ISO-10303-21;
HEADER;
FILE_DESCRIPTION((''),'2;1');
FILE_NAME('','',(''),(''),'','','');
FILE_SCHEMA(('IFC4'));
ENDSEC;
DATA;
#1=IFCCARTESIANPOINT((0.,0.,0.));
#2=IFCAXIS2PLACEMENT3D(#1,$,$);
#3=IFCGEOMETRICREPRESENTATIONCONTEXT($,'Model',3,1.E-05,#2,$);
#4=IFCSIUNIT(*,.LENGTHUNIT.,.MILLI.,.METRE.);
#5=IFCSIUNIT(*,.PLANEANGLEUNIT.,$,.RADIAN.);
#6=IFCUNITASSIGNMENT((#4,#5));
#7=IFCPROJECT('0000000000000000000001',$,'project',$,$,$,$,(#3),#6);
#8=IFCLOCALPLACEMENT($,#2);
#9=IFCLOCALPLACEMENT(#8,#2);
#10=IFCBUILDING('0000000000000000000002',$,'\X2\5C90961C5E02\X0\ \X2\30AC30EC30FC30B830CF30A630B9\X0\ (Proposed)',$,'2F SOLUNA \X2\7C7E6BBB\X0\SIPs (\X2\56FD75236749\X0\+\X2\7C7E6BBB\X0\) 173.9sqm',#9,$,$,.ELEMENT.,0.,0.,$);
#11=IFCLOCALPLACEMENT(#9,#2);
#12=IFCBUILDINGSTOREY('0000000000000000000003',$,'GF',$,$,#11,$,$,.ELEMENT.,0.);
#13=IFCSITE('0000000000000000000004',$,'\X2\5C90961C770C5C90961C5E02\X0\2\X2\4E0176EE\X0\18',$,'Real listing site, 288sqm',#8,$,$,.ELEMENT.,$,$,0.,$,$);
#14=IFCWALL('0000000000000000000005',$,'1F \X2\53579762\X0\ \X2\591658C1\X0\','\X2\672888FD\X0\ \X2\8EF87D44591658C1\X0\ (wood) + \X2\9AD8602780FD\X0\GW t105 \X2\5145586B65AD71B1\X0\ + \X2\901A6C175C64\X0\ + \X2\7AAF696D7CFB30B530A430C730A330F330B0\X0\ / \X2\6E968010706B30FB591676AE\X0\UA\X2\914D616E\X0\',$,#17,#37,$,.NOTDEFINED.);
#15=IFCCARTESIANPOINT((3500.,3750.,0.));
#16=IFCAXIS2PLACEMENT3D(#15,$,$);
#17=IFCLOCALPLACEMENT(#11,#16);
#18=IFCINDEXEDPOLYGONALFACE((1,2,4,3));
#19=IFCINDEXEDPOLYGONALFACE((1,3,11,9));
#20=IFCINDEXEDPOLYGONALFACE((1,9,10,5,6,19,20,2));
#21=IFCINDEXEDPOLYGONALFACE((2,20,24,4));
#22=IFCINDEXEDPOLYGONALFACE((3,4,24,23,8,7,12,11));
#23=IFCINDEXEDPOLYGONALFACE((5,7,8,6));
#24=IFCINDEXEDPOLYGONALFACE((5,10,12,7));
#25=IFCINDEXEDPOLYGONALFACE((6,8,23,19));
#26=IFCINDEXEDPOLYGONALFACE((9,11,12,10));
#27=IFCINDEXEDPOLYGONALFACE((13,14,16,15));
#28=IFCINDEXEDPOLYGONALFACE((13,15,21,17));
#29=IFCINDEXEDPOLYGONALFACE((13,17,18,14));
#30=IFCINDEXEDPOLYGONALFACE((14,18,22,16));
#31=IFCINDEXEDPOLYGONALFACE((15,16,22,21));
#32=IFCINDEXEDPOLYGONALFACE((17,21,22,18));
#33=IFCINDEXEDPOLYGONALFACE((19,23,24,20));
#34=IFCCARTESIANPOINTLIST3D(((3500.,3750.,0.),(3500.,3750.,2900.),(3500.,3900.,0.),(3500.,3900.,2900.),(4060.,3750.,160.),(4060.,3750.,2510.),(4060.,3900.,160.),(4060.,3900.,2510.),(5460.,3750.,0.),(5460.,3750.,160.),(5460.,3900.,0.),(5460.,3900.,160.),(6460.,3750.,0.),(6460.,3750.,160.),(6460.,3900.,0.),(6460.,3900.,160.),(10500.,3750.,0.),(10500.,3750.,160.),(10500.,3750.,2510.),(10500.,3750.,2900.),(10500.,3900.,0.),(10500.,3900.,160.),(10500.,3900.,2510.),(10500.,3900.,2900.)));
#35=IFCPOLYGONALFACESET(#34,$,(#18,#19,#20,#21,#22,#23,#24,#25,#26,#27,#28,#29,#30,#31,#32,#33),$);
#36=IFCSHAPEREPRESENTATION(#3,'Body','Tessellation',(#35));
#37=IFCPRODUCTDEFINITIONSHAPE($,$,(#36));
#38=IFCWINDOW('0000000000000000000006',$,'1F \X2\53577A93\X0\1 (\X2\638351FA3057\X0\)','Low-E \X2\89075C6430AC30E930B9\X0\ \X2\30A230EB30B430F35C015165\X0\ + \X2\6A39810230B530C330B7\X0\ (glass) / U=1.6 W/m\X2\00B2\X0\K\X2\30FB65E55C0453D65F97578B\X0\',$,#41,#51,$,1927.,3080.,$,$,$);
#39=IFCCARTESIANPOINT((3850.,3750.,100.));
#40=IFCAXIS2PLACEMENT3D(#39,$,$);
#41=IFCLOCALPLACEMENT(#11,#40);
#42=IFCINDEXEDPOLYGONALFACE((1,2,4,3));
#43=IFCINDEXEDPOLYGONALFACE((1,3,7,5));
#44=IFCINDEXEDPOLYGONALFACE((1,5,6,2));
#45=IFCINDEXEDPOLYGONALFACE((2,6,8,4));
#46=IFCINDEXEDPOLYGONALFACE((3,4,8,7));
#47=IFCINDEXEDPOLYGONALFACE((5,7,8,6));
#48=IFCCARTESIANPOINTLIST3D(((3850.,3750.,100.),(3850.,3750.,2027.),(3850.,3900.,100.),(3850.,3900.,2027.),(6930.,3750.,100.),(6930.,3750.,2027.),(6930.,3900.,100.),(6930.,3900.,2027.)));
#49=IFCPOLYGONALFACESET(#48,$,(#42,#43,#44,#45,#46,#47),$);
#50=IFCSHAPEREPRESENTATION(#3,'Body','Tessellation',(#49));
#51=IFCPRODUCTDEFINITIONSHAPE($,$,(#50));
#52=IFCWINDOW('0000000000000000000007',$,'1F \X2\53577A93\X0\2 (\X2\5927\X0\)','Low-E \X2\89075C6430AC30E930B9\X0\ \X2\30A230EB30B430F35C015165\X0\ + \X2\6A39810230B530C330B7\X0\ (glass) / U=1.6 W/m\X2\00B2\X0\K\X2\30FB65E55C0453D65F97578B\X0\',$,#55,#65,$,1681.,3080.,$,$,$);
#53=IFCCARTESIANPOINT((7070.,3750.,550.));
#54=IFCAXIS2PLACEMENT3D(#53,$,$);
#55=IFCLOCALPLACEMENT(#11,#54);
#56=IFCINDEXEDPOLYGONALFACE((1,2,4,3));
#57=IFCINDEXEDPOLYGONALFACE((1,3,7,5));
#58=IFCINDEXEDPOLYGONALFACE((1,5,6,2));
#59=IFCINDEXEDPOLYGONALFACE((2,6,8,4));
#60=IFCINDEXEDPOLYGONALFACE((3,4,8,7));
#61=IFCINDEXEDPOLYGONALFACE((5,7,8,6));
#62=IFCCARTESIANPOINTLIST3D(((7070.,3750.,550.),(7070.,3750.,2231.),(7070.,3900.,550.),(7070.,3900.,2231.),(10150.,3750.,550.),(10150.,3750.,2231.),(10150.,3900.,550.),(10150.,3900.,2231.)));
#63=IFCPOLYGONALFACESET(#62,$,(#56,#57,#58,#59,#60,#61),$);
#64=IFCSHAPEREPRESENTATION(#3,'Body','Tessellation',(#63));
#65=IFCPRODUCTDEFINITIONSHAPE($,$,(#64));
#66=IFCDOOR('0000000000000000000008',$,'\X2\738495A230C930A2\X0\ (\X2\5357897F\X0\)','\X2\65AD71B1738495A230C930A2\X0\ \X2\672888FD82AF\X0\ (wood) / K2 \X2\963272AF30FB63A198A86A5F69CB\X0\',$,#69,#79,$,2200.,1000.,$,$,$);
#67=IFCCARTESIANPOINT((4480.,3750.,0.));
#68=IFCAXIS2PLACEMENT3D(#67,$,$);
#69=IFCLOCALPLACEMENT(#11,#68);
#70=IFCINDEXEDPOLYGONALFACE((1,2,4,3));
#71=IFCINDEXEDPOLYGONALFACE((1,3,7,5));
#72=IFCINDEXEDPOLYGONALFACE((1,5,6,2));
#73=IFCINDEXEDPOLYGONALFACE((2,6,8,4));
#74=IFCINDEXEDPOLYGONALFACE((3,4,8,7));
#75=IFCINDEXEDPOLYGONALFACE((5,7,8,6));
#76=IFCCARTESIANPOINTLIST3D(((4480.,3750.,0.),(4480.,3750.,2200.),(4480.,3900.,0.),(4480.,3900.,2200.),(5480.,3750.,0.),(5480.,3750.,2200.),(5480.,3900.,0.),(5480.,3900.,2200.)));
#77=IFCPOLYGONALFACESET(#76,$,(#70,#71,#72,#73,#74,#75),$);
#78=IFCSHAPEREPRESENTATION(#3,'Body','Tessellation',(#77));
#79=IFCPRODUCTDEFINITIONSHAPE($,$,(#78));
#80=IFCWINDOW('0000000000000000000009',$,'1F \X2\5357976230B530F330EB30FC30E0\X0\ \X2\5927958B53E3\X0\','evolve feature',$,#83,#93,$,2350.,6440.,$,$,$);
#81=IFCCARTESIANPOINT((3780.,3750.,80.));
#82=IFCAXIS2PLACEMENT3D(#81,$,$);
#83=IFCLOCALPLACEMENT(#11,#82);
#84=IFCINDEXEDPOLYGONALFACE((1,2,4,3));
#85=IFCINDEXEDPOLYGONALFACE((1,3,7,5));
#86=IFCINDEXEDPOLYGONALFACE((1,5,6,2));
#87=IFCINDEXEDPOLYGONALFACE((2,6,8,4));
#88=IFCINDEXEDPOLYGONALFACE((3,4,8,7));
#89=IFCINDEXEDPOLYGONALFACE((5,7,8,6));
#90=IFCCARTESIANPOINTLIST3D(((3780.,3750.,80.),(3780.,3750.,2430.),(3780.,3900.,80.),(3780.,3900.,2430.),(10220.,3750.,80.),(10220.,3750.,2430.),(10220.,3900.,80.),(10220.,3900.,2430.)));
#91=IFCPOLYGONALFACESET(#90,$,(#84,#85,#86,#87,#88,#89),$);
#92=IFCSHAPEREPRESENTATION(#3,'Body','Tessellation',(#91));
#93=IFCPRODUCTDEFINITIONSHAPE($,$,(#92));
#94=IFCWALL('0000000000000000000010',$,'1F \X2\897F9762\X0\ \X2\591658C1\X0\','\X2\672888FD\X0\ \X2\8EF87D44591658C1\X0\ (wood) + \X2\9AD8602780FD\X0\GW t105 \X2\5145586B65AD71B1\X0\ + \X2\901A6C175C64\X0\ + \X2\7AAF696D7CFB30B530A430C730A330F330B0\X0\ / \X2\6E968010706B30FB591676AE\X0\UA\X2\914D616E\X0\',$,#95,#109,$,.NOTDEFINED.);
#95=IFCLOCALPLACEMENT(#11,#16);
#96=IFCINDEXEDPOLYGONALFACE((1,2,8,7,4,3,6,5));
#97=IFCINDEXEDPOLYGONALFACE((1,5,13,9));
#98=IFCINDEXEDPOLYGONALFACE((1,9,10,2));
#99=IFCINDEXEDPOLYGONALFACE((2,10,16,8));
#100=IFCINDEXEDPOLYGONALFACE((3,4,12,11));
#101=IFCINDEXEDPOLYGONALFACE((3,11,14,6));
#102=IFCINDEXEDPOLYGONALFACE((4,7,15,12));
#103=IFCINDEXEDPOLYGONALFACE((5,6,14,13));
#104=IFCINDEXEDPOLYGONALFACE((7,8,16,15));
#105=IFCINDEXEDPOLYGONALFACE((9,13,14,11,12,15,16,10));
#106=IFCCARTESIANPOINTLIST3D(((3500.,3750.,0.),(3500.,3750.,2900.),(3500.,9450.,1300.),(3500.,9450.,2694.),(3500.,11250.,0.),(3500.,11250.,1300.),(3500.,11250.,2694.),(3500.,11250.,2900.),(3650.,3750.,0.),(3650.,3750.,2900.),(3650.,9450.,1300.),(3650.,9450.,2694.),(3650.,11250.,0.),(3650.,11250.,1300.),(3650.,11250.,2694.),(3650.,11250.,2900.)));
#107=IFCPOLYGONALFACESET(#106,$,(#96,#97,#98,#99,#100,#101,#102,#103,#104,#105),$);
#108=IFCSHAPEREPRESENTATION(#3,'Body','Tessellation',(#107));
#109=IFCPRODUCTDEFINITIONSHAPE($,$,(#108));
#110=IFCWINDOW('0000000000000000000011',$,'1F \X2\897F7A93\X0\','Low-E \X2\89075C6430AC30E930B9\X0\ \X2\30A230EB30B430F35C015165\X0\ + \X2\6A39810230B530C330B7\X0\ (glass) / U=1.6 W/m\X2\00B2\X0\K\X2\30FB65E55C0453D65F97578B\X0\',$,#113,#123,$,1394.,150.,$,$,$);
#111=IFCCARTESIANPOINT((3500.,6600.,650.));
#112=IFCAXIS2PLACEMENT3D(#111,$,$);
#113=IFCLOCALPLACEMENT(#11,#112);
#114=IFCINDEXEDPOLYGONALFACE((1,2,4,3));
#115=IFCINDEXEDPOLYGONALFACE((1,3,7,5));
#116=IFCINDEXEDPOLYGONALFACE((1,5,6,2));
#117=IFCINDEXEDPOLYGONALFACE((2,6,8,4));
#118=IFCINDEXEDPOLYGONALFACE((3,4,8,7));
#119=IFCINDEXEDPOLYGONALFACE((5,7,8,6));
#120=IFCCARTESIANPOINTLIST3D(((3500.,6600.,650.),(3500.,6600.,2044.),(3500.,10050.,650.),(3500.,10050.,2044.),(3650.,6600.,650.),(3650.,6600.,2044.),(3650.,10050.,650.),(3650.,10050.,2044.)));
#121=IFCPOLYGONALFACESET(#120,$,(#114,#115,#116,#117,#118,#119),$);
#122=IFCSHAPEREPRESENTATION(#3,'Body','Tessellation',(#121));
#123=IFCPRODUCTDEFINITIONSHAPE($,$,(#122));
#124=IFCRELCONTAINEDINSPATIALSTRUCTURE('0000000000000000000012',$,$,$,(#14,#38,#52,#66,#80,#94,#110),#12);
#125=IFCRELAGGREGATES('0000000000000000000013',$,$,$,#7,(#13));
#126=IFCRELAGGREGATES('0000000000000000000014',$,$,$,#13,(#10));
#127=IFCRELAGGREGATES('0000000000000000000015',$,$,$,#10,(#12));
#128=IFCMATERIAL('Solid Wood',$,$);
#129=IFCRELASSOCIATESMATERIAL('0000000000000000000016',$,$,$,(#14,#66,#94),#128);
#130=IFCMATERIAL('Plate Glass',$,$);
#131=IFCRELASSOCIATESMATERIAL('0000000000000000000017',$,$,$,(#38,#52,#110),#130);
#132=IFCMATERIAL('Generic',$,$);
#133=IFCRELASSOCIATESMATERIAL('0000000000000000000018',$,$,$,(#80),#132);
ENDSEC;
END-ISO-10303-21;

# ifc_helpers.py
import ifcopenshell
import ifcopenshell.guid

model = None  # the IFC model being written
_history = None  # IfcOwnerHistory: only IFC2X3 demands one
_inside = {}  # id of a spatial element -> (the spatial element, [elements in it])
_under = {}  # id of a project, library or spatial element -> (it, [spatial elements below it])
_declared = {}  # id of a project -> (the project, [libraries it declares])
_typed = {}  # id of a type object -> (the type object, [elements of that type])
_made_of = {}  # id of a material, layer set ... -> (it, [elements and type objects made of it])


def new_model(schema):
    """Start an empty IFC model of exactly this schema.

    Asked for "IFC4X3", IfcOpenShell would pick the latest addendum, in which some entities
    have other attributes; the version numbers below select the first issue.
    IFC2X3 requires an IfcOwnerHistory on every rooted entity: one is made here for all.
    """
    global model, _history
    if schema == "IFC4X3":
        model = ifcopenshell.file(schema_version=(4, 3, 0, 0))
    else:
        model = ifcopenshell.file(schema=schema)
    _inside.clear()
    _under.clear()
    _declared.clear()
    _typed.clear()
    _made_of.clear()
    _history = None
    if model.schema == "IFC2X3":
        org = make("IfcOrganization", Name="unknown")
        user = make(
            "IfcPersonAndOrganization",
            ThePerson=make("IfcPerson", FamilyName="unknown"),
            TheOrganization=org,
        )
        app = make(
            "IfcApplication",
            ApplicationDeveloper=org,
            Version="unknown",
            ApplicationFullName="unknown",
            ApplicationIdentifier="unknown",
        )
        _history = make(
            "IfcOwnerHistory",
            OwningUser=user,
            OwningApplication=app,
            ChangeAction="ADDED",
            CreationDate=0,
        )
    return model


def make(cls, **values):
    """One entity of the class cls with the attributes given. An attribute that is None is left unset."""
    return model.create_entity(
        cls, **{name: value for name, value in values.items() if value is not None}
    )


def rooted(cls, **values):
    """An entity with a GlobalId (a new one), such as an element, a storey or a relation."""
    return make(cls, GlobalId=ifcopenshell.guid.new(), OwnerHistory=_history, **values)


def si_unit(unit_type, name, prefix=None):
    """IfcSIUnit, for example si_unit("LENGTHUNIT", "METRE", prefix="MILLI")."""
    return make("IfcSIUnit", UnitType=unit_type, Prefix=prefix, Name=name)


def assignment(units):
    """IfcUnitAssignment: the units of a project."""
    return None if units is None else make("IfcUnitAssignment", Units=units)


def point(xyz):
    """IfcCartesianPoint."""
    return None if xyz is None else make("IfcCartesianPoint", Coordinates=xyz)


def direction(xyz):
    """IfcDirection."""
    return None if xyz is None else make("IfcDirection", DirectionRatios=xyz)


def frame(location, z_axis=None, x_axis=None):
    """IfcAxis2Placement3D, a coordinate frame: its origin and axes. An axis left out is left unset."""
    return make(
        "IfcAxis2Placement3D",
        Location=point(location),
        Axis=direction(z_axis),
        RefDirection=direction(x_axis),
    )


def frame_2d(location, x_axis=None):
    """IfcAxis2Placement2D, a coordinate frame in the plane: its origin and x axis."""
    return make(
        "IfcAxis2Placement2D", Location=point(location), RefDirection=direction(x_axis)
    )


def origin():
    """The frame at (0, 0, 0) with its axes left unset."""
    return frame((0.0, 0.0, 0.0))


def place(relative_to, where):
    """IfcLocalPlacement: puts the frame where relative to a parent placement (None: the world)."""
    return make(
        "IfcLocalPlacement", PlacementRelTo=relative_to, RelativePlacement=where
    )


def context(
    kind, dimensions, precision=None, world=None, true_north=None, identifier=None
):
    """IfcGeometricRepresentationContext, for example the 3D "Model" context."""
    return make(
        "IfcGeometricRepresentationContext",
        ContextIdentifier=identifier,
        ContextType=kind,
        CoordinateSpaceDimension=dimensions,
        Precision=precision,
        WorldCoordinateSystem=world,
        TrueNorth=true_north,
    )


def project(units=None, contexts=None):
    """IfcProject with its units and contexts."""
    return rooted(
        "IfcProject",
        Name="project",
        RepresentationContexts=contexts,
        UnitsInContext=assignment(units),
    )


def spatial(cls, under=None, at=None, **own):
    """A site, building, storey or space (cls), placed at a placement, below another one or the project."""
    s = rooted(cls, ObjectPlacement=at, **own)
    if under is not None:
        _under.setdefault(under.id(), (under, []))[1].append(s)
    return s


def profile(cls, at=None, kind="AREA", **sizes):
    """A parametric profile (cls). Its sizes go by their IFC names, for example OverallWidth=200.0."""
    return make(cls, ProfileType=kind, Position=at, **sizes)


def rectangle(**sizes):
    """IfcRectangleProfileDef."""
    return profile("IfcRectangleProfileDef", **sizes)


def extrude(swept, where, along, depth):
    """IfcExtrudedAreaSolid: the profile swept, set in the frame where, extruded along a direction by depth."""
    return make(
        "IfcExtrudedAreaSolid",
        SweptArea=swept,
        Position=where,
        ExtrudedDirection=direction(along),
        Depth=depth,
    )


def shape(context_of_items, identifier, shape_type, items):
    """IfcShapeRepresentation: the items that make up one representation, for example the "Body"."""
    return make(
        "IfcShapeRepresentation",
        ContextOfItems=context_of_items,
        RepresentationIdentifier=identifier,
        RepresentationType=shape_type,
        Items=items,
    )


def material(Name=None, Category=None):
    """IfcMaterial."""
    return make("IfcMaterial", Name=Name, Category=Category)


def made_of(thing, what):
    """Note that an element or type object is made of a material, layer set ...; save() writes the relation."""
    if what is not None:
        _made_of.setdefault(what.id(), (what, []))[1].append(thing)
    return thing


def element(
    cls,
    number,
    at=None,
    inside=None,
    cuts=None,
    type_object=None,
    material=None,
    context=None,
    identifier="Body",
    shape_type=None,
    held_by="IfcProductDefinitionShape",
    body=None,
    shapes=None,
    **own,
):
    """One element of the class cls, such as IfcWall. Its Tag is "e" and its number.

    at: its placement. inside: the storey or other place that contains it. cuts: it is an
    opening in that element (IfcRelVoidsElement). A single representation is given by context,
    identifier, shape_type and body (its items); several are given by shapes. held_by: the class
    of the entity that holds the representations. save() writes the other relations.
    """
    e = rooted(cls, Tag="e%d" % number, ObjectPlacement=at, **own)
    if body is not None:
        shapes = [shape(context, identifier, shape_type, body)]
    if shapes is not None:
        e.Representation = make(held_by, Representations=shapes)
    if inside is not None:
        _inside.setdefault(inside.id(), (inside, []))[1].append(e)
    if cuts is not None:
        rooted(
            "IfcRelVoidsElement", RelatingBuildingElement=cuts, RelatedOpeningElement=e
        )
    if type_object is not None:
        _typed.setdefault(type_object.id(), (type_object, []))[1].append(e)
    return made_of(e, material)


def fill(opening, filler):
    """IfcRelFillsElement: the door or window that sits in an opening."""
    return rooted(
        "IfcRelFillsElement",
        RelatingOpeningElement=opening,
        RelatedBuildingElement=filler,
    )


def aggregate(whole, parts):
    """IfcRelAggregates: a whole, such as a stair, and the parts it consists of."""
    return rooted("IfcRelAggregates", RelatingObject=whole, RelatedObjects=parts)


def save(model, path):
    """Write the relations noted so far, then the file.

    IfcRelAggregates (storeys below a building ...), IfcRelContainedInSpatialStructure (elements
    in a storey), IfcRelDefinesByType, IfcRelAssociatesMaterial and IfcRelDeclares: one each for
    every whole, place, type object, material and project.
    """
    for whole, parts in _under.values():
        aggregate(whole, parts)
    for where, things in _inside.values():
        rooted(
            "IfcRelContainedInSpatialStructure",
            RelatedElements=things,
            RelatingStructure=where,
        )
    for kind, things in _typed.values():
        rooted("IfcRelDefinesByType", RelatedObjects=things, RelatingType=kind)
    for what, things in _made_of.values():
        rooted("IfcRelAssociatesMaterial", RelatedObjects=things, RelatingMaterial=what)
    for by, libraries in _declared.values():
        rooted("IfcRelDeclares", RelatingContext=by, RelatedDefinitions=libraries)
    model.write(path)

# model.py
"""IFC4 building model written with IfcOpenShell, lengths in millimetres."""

from ifc_helpers import new_model, si_unit, frame, frame_2d, origin, place, context, project, spatial, rectangle, extrude, material, element, fill, save


model = new_model("IFC4")

# Units and contexts
model_context = context("Model", 3, precision=1e-05, world=origin())
ifc_project = project(units=[si_unit("LENGTHUNIT", "METRE", prefix="MILLI"), si_unit("PLANEANGLEUNIT", "RADIAN")], contexts=[model_context])

# Site, building, storey
site_placement = place(None, origin())
site = spatial("IfcSite", under=ifc_project, at=site_placement, Name="岐阜県岐阜市2丁目18", ObjectType="Real listing site, 288sqm", CompositionType="ELEMENT", RefElevation=0.0)
building_placement = place(site_placement, origin())
building = spatial("IfcBuilding", under=site, at=building_placement, Name="岐阜市 ガレージハウス (Proposed)", ObjectType="2F SOLUNA 籾殻SIPs (国産杉+籾殻) 173.9sqm", CompositionType="ELEMENT", ElevationOfRefHeight=0.0, ElevationOfTerrain=0.0)
storey_placement = place(building_placement, origin())
storey = spatial("IfcBuildingStorey", under=building, at=storey_placement, Name="GF", CompositionType="ELEMENT", Elevation=0.0)

# Shared definitions
ifc_material_1 = material(Name="Solid Wood")
ifc_material_2 = material(Name="Generic")

# Wall, openings, windows, door
wall_1_placement = place(storey_placement, frame((3500.0, 3750.0, 0.0)))
wall_1 = element("IfcWall", 1, at=wall_1_placement, inside=storey, material=ifc_material_1, Name="1F 南面 外壁", Description="木製 軸組外壁 (wood) + 高性能GW t105 充填断熱 + 通気層 + 窯業系サイディング / 準耐火・外皮UA配慮", PredefinedType="NOTDEFINED", context=model_context, shape_type="SweptSolid", body=[
    extrude(rectangle(XDim=7000.0, YDim=150.0, at=frame_2d((3500.0, 75.0))), frame((3500.0, 3750.0, 0.0)), (0.0, 0.0, 1.0), 2900.0),
])
opening_1_placement = place(storey_placement, frame((3850.0, 3750.0, 100.0)))
opening_1 = element("IfcOpeningElement", 2, at=opening_1_placement, cuts=wall_1, PredefinedType="NOTDEFINED", context=model_context, shape_type="SweptSolid", body=[
    extrude(rectangle(XDim=3080.0, YDim=150.0, at=frame_2d((1540.0, 75.0))), frame((3850.0, 3750.0, 100.0)), (0.0, 0.0, 1.0), 1927.0),
])
opening_2_placement = place(storey_placement, frame((7070.0, 3750.0, 550.0)))
opening_2 = element("IfcOpeningElement", 3, at=opening_2_placement, cuts=wall_1, PredefinedType="NOTDEFINED", context=model_context, shape_type="SweptSolid", body=[
    extrude(rectangle(XDim=3080.0, YDim=150.0, at=frame_2d((1540.0, 75.0))), frame((7070.0, 3750.0, 550.0)), (0.0, 0.0, 1.0), 1681.0),
])
opening_3_placement = place(storey_placement, frame((4480.0, 3750.0, 0.0)))
opening_3 = element("IfcOpeningElement", 4, at=opening_3_placement, cuts=wall_1, PredefinedType="NOTDEFINED", context=model_context, shape_type="SweptSolid", body=[
    extrude(rectangle(XDim=1000.0, YDim=150.0, at=frame_2d((500.0, 75.0))), frame((4480.0, 3750.0, 0.0)), (0.0, 0.0, 1.0), 2200.0),
])
opening_4_placement = place(storey_placement, frame((3780.0, 3750.0, 80.0)))
opening_4 = element("IfcOpeningElement", 5, at=opening_4_placement, cuts=wall_1, PredefinedType="NOTDEFINED", context=model_context, shape_type="SweptSolid", body=[
    extrude(rectangle(XDim=6440.0, YDim=150.0, at=frame_2d((3220.0, 75.0))), frame((3780.0, 3750.0, 80.0)), (0.0, 0.0, 1.0), 2350.0),
])
ifc_material_3 = material(Name="Plate Glass")
window_1_placement = place(storey_placement, frame((3850.0, 3750.0, 100.0)))
window_1 = element("IfcWindow", 6, at=window_1_placement, inside=storey, material=ifc_material_3, Name="1F 南窓1 (掃出し)", Description="Low-E 複層ガラス アルゴン封入 + 樹脂サッシ (glass) / U=1.6 W/m²K・日射取得型", OverallHeight=1927.0, OverallWidth=3080.0, context=model_context, shape_type="SweptSolid", body=[
    extrude(rectangle(XDim=3080.0, YDim=150.0, at=frame_2d((1540.0, 75.0))), frame((3850.0, 3750.0, 100.0)), (0.0, 0.0, 1.0), 1927.0),
])
fill(opening_1, window_1)
window_2_placement = place(storey_placement, frame((7070.0, 3750.0, 550.0)))
window_2 = element("IfcWindow", 7, at=window_2_placement, inside=storey, material=ifc_material_3, Name="1F 南窓2 (大)", Description="Low-E 複層ガラス アルゴン封入 + 樹脂サッシ (glass) / U=1.6 W/m²K・日射取得型", OverallHeight=1681.0, OverallWidth=3080.0, context=model_context, shape_type="SweptSolid", body=[
    extrude(rectangle(XDim=3080.0, YDim=150.0, at=frame_2d((1540.0, 75.0))), frame((7070.0, 3750.0, 550.0)), (0.0, 0.0, 1.0), 1681.0),
])
fill(opening_2, window_2)
door_placement = place(storey_placement, frame((4480.0, 3750.0, 0.0)))
door = element("IfcDoor", 8, at=door_placement, inside=storey, material=ifc_material_1, Name="玄関ドア (南西)", Description="断熱玄関ドア 木製芯 (wood) / K2 防犯・採風機構", OverallHeight=2200.0, OverallWidth=1000.0, context=model_context, shape_type="SweptSolid", body=[
    extrude(rectangle(XDim=1000.0, YDim=150.0, at=frame_2d((500.0, 75.0))), frame((4480.0, 3750.0, 0.0)), (0.0, 0.0, 1.0), 2200.0),
])
fill(opening_3, door)
window_3_placement = place(storey_placement, frame((3780.0, 3750.0, 80.0)))
window_3 = element("IfcWindow", 9, at=window_3_placement, inside=storey, material=ifc_material_2, Name="1F 南面サンルーム 大開口", Description="evolve feature", OverallHeight=2350.0, OverallWidth=6440.0, context=model_context, shape_type="SweptSolid", body=[
    extrude(rectangle(XDim=6440.0, YDim=150.0, at=frame_2d((3220.0, 75.0))), frame((3780.0, 3750.0, 80.0)), (0.0, 0.0, 1.0), 2350.0),
])
fill(opening_4, window_3)

# Wall, opening, window
wall_2_placement = place(storey_placement, frame((3500.0, 3750.0, 0.0)))
wall_2 = element("IfcWall", 10, at=wall_2_placement, inside=storey, material=ifc_material_1, Name="1F 西面 外壁", Description="木製 軸組外壁 (wood) + 高性能GW t105 充填断熱 + 通気層 + 窯業系サイディング / 準耐火・外皮UA配慮", PredefinedType="NOTDEFINED", context=model_context, shape_type="SweptSolid", body=[
    extrude(rectangle(XDim=150.0, YDim=7500.0, at=frame_2d((75.0, 3750.0))), frame((3500.0, 3750.0, 0.0)), (0.0, 0.0, 1.0), 2900.0),
])
opening_5_placement = place(storey_placement, frame((3500.0, 6600.0, 650.0)))
opening_5 = element("IfcOpeningElement", 11, at=opening_5_placement, cuts=wall_2, PredefinedType="NOTDEFINED", context=model_context, shape_type="SweptSolid", body=[
    extrude(rectangle(XDim=150.0, YDim=3450.0, at=frame_2d((75.0, 1725.0))), frame((3500.0, 6600.0, 650.0)), (0.0, 0.0, 1.0), 1394.0),
])
window_4_placement = place(storey_placement, frame((3500.0, 6600.0, 650.0)))
window_4 = element("IfcWindow", 12, at=window_4_placement, inside=storey, material=ifc_material_3, Name="1F 西窓", Description="Low-E 複層ガラス アルゴン封入 + 樹脂サッシ (glass) / U=1.6 W/m²K・日射取得型", OverallHeight=1394.0, OverallWidth=150.0, context=model_context, shape_type="SweptSolid", body=[
    extrude(rectangle(XDim=150.0, YDim=3450.0, at=frame_2d((75.0, 1725.0))), frame((3500.0, 6600.0, 650.0)), (0.0, 0.0, 1.0), 1394.0),
])
fill(opening_5, window_4)

save(model, "model.ifc")
